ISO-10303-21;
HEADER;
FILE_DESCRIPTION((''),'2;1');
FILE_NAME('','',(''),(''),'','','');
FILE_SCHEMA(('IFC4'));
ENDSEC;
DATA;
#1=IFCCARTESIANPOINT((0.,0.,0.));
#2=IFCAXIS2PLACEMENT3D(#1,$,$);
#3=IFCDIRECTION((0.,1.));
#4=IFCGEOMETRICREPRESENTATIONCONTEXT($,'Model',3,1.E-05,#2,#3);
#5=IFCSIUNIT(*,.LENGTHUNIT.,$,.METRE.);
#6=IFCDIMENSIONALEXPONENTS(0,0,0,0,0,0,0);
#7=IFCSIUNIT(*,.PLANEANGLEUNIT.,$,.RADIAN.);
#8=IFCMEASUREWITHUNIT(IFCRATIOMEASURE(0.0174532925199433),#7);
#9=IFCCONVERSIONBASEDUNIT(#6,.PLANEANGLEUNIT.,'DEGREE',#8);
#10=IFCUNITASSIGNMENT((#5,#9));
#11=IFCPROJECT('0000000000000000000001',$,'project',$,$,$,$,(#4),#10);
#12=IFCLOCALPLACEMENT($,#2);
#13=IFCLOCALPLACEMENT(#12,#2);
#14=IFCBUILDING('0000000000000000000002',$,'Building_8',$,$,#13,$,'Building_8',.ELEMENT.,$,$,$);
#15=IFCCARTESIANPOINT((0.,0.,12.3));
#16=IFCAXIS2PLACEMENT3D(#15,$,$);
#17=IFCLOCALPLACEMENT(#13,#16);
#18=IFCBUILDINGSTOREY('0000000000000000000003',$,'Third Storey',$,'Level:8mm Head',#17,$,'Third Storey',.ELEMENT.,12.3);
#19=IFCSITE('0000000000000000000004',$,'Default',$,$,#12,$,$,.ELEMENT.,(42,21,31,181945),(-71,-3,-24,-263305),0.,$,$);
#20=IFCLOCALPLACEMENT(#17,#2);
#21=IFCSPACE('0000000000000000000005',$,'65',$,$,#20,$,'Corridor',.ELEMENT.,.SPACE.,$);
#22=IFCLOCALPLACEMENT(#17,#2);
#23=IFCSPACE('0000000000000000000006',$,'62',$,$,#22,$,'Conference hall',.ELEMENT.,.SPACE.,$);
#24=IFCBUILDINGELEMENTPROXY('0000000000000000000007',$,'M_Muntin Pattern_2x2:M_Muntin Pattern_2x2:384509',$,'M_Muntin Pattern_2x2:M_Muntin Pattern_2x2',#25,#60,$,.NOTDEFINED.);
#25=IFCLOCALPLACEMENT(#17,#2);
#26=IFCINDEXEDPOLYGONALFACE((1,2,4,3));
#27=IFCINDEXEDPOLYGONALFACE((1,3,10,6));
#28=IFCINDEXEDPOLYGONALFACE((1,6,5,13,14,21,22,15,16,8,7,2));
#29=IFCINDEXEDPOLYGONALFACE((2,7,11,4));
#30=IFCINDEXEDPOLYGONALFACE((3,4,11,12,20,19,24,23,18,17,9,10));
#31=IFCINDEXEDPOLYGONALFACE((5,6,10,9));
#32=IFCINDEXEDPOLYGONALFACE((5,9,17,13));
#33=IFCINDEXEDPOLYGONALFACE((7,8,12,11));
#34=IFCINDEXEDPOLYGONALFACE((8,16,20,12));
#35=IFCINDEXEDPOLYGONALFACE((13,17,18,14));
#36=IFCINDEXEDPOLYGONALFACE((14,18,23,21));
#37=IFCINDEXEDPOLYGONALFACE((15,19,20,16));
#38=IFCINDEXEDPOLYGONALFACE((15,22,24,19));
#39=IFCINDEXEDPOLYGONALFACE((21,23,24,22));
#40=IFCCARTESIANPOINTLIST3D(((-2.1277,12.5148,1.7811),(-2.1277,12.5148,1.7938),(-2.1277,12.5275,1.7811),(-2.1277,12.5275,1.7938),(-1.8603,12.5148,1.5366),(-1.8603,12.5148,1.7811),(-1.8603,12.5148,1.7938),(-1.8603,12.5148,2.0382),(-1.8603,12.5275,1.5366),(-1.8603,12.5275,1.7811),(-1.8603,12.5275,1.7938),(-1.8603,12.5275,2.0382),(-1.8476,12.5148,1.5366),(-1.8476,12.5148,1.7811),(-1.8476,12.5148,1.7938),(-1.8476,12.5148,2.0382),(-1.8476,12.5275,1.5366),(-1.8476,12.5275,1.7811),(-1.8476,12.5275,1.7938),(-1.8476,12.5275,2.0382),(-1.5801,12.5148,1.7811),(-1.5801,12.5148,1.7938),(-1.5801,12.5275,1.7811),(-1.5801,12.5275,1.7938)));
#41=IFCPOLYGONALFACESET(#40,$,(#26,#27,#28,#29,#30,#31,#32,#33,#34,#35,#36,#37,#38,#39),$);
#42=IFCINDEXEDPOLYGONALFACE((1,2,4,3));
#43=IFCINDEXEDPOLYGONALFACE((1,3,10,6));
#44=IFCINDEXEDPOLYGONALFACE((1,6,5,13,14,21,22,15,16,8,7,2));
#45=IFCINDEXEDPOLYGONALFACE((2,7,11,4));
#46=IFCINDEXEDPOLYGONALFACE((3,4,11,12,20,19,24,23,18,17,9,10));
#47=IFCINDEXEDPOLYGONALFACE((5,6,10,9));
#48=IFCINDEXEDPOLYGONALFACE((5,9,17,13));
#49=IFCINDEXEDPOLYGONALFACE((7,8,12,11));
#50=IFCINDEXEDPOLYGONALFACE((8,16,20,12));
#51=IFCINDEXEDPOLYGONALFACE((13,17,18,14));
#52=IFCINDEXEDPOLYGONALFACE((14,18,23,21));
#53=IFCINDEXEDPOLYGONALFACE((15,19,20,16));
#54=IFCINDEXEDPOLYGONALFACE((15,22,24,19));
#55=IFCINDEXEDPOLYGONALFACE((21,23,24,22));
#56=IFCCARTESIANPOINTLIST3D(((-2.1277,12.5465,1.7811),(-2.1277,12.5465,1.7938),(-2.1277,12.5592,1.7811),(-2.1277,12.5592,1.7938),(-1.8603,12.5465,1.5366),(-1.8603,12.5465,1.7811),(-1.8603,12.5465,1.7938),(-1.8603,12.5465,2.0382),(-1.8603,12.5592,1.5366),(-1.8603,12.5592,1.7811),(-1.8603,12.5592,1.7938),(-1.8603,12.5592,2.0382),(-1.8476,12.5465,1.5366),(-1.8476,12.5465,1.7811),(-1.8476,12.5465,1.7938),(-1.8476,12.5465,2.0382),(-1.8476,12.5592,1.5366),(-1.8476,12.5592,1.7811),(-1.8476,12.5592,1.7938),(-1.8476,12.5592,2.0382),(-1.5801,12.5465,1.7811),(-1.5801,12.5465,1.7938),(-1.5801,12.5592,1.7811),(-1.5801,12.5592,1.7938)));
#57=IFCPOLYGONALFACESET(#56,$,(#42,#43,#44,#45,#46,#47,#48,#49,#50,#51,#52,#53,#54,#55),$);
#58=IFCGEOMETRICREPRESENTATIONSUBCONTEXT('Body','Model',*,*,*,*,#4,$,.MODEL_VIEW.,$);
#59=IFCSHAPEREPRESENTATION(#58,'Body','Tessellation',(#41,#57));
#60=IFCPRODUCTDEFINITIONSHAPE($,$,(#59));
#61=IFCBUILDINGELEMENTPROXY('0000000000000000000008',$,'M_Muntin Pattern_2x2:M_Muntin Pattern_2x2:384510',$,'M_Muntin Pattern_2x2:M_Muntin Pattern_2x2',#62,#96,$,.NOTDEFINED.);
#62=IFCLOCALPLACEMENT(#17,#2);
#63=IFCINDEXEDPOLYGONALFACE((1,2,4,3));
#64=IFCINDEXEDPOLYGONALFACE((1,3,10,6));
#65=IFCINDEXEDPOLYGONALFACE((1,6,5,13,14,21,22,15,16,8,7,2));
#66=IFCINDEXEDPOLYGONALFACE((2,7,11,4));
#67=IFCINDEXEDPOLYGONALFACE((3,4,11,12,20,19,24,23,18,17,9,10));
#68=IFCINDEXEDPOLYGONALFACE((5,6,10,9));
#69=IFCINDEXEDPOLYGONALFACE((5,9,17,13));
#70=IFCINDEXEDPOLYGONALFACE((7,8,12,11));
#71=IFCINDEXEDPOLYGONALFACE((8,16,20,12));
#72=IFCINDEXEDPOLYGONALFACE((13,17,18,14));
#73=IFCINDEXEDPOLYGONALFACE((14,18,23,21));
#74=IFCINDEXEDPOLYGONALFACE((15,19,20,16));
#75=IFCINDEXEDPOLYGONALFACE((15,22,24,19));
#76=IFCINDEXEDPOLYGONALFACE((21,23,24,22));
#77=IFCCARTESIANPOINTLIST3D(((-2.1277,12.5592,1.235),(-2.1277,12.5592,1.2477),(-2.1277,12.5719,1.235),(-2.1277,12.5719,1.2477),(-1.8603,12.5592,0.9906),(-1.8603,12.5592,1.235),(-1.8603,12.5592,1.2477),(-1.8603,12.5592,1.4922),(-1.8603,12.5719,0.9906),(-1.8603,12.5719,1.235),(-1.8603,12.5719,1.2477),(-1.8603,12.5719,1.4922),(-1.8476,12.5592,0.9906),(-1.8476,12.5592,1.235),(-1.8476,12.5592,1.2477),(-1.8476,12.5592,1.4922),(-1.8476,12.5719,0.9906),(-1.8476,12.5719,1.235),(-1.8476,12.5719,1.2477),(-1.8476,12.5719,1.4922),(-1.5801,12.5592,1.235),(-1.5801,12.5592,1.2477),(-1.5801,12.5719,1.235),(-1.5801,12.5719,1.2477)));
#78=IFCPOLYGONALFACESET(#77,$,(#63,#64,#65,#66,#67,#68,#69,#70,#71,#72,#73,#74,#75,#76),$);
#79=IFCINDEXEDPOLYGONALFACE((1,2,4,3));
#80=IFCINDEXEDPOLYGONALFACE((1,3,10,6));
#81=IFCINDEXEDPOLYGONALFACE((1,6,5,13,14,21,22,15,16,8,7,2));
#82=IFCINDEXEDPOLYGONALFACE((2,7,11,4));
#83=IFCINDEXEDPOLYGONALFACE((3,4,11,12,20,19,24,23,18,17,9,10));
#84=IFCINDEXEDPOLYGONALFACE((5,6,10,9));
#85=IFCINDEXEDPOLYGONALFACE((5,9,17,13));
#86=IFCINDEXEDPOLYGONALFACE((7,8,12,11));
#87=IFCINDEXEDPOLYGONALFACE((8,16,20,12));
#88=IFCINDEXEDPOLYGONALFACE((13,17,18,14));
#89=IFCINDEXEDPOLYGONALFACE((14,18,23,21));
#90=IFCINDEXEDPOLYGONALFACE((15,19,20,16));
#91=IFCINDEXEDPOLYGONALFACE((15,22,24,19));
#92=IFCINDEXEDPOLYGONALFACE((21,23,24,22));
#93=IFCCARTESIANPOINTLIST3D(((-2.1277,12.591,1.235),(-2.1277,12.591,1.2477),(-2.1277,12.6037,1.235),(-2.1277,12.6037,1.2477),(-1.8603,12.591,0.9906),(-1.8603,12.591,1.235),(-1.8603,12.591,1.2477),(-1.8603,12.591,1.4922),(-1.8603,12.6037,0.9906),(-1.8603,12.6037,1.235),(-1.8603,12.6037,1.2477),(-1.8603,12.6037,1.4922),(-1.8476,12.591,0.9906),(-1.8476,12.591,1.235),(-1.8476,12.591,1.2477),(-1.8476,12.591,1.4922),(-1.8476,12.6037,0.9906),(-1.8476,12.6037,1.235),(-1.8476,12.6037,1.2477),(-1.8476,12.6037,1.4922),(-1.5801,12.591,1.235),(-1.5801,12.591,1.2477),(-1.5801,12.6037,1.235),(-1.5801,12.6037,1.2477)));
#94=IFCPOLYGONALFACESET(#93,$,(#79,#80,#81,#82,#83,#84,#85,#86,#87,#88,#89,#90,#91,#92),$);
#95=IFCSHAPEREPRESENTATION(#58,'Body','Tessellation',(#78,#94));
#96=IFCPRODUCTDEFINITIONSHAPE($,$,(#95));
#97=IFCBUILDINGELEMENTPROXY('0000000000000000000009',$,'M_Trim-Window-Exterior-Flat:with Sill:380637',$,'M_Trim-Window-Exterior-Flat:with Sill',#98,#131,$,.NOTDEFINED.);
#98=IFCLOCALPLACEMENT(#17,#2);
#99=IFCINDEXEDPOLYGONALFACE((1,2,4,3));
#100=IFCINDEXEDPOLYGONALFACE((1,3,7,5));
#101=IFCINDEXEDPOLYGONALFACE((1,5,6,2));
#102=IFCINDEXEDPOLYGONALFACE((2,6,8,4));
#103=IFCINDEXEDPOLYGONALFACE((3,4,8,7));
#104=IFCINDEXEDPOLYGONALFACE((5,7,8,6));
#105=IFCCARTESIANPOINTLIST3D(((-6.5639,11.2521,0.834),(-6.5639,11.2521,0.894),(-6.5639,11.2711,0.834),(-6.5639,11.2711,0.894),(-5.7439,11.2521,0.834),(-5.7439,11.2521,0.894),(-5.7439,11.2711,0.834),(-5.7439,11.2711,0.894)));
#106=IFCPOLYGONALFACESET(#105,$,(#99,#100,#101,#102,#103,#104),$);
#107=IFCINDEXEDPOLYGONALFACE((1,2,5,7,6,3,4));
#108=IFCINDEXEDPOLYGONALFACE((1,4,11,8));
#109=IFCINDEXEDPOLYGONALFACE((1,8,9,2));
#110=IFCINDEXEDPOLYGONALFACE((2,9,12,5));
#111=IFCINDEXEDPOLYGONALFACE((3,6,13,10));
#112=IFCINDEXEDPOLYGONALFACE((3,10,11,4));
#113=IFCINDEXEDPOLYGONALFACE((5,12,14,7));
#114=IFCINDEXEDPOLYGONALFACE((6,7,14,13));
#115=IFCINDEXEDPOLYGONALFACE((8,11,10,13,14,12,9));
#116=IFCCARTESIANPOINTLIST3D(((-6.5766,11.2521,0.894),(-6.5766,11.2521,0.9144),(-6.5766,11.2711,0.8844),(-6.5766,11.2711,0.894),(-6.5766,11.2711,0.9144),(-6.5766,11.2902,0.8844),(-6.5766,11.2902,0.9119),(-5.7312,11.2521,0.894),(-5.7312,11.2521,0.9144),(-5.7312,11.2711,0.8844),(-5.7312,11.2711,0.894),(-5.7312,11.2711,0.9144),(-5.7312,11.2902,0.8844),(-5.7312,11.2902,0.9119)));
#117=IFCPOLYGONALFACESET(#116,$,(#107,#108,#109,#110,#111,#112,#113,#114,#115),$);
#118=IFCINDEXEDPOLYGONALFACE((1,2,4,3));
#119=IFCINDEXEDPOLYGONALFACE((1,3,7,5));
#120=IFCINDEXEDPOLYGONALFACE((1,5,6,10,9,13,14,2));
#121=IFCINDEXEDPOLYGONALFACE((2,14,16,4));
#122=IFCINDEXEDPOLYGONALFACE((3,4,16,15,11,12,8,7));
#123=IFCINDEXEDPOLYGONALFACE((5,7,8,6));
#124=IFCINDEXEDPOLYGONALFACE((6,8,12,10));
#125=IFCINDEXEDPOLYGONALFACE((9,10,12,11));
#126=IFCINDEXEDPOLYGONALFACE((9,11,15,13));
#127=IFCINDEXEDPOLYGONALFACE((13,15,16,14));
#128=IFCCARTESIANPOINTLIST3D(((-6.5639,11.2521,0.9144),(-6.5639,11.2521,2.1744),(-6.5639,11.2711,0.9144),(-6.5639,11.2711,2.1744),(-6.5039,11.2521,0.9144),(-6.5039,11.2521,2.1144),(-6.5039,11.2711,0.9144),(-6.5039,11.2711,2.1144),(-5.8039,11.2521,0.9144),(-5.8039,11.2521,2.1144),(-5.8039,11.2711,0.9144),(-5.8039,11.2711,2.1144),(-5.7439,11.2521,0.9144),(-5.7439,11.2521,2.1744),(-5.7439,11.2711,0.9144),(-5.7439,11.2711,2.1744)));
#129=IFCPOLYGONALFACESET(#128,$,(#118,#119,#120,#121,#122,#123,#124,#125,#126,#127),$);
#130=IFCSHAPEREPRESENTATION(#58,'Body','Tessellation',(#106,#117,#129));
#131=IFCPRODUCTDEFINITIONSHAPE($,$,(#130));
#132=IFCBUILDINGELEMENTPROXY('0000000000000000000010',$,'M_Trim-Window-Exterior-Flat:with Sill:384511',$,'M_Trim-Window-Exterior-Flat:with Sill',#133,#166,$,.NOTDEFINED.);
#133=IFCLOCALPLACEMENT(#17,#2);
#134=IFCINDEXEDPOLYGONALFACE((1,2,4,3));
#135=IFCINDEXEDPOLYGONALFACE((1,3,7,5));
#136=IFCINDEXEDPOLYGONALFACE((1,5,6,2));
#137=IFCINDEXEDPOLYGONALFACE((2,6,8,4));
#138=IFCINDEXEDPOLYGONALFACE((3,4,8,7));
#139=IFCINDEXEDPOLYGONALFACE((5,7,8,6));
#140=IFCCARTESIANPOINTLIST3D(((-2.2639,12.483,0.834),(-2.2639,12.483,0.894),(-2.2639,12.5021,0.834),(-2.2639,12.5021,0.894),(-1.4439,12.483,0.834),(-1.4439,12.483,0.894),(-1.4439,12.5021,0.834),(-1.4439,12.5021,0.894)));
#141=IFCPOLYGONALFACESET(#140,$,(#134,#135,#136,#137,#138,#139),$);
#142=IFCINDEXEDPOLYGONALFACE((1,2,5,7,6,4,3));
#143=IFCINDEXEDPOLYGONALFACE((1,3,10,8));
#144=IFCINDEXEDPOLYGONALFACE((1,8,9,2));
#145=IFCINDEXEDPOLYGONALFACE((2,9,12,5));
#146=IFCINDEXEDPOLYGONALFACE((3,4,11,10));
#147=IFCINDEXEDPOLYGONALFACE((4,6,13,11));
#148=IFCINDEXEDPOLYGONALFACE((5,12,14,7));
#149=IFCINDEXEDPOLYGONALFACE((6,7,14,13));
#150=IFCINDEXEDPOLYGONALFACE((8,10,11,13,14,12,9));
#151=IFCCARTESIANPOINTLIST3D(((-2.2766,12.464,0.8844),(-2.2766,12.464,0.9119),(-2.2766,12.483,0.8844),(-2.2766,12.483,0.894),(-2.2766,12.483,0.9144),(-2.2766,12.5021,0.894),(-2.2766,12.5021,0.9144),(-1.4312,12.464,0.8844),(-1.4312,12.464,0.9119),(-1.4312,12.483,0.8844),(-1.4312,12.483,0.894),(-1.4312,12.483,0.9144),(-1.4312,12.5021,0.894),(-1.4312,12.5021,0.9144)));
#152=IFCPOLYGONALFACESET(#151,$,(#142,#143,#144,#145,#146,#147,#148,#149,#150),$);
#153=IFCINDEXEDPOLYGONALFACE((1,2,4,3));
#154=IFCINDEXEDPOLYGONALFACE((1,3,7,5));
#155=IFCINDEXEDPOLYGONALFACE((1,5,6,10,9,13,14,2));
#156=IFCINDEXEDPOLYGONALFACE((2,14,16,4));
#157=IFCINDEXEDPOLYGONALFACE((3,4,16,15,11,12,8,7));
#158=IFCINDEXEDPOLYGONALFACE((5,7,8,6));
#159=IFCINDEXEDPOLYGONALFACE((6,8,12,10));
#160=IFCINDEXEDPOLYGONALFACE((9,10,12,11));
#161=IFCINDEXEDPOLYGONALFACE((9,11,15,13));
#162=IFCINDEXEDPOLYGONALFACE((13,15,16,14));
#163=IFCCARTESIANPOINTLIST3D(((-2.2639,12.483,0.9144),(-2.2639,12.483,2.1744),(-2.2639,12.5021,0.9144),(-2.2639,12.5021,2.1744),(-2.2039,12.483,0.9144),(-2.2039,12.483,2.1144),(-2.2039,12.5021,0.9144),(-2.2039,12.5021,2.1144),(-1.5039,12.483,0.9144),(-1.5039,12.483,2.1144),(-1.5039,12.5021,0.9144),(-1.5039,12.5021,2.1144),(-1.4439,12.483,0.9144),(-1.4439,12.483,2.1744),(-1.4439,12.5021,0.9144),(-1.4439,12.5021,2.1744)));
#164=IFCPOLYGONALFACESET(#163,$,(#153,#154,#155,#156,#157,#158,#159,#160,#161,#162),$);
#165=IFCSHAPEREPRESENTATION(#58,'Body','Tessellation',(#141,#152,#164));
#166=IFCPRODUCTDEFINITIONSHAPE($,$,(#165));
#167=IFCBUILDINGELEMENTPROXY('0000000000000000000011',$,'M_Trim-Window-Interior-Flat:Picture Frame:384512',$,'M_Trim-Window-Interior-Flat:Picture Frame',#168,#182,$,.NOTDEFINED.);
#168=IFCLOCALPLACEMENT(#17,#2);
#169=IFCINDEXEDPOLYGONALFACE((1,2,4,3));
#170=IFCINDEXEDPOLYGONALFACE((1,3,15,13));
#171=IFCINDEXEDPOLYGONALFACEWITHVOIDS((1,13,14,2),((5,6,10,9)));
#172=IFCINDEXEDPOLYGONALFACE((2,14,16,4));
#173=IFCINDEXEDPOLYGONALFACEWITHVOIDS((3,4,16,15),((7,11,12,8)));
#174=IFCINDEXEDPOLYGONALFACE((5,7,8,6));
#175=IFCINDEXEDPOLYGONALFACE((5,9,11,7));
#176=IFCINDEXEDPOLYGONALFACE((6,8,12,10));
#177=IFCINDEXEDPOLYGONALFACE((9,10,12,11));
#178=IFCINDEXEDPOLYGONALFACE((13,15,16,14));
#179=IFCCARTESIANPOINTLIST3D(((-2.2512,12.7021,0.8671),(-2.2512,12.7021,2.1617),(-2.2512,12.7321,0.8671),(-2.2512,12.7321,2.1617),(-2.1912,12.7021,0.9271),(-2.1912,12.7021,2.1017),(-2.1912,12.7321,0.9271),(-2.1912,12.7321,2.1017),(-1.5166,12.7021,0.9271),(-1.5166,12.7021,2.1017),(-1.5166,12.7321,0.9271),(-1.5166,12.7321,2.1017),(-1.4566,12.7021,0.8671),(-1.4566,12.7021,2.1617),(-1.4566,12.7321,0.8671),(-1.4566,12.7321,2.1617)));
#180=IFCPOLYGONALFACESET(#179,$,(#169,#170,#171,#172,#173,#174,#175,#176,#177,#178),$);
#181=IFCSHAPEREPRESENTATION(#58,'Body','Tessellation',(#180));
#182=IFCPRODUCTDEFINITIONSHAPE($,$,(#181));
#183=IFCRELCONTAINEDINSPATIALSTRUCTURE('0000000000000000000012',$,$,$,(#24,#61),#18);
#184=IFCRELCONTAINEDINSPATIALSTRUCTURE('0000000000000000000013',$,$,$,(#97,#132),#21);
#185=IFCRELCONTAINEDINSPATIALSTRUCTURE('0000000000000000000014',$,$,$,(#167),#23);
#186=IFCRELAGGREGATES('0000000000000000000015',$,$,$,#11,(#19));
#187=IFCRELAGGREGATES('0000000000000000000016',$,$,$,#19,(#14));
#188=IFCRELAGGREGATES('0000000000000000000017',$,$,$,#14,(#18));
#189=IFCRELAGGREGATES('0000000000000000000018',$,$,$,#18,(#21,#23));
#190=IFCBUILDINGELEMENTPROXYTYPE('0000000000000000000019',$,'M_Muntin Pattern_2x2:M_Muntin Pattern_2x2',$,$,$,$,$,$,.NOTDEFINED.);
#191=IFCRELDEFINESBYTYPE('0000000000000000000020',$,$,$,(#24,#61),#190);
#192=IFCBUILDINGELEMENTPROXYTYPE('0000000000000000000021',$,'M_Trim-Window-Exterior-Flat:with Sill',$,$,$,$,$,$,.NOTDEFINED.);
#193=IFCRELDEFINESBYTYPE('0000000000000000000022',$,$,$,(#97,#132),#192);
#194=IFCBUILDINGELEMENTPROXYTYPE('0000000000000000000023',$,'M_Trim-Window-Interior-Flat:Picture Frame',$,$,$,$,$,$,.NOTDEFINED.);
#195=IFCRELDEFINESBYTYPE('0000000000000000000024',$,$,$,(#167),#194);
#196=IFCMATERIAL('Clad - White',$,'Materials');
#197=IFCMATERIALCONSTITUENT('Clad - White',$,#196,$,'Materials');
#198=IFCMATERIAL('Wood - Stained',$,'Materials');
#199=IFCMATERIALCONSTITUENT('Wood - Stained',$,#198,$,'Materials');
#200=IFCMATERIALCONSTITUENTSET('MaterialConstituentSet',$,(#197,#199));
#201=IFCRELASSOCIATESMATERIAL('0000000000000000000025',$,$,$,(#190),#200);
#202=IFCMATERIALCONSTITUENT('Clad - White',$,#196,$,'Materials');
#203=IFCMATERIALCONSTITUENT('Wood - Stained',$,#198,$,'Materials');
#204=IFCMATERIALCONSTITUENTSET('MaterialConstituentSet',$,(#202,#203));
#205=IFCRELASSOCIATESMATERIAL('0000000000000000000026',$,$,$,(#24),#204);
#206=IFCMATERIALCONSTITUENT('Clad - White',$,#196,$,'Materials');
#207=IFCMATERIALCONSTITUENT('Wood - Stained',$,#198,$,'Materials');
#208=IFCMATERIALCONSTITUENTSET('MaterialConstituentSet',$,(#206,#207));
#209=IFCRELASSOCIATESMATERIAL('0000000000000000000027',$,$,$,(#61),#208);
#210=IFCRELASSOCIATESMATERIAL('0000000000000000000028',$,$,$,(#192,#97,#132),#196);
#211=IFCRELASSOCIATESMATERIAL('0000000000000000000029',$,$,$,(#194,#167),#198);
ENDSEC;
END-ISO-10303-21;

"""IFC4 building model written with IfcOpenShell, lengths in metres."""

from ifc_helpers import new_model, entity, si_unit, converted_unit, direction, frame, origin, place, context, subcontext, project, spatial, indexed_curve, outline, extrude, source, transform, mapped, material, constituent, constituent_set, type_object, type_shapes, element, save


model = new_model("IFC4")

# Units and contexts
model_context = context("Model", 3, precision=1e-05, world=origin(), true_north=direction((0.0, 1.0)))
body_context = subcontext(model_context, "Body", "Model", "MODEL_VIEW")
ifc_project = project(units=[si_unit("LENGTHUNIT", "METRE"), converted_unit("PLANEANGLEUNIT", "DEGREE", entity("IfcRatioMeasure", 0.0174532925199433), si_unit("PLANEANGLEUNIT", "RADIAN"), dimensions=[0, 0, 0, 0, 0, 0, 0])], contexts=[model_context])

# Site, building, storey
site_placement = place(None, origin())
site = spatial("IfcSite", under=ifc_project, at=site_placement, Name="Default", CompositionType="ELEMENT", RefLatitude=(42, 21, 31, 181945), RefLongitude=(-71, -3, -24, -263305), RefElevation=0.0)
building_placement = place(site_placement, origin())
building = spatial("IfcBuilding", under=site, at=building_placement, Name="Building_8", LongName="Building_8", CompositionType="ELEMENT")
storey_placement = place(building_placement, frame((0.0, 0.0, 12.3)))
storey = spatial("IfcBuildingStorey", under=building, at=storey_placement, Name="Third Storey", ObjectType="Level:8mm Head", LongName="Third Storey", CompositionType="ELEMENT", Elevation=12.3)

# Building element proxies
ifc_material_1 = material(Name="Clad - White", Category="Materials")
ifc_constituent_1 = constituent(ifc_material_1, Name="Clad - White", Category="Materials")
ifc_material_2 = material(Name="Wood - Stained", Category="Materials")
ifc_constituent_2 = constituent(ifc_material_2, Name="Wood - Stained", Category="Materials")
ifc_constituent_set_1 = constituent_set(constituents=[ifc_constituent_1, ifc_constituent_2], Name="MaterialConstituentSet")
ifc_constituent_3 = constituent(ifc_material_1, Name="Clad - White", Category="Materials")
ifc_constituent_4 = constituent(ifc_material_2, Name="Wood - Stained", Category="Materials")
ifc_constituent_set_2 = constituent_set(constituents=[ifc_constituent_3, ifc_constituent_4], Name="MaterialConstituentSet")
building_element_proxy_type_1 = type_object("IfcBuildingElementProxyType", Name="M_Muntin Pattern_2x2:M_Muntin Pattern_2x2", PredefinedType="NOTDEFINED", material=ifc_constituent_set_2)
shared_shape_1 = source(origin(), body_context, "Body", "SweptSolid", [
    extrude(outline(indexed_curve([(0.0064, -0.0064), (0.2508, -0.0064), (0.2508, 0.0063), (0.0064, 0.0063), (0.0064, 0.2738), (-0.0063, 0.2738), (-0.0063, 0.0063), (-0.2508, 0.0063), (-0.2508, -0.0064), (-0.0063, -0.0064), (-0.0063, -0.2738), (0.0064, -0.2738), (0.0064, -0.0064)], self_intersect=False)), frame((0.0, -0.0222, 0.2508), z_axis=(0.0, 1.0, 0.0), x_axis=(0.0, 0.0, 1.0)), (0.0, 0.0, 1.0), 0.0127),
    extrude(outline(indexed_curve([(0.0064, -0.0064), (0.2508, -0.0064), (0.2508, 0.0063), (0.0064, 0.0063), (0.0064, 0.2738), (-0.0063, 0.2738), (-0.0063, 0.0063), (-0.2508, 0.0063), (-0.2508, -0.0064), (-0.0063, -0.0064), (-0.0063, -0.2738), (0.0064, -0.2738), (0.0064, -0.0064)], self_intersect=False)), frame((0.0, 0.0095, 0.2508), z_axis=(0.0, 1.0, 0.0), x_axis=(0.0, 0.0, 1.0)), (0.0, 0.0, 1.0), 0.0127),
])
type_shapes(building_element_proxy_type_1, [shared_shape_1])
proxy_1_placement = place(storey_placement, frame((-1.8539, 12.537, 1.5366)))
element("IfcBuildingElementProxy", 1, at=proxy_1_placement, inside=storey, type_object=building_element_proxy_type_1, material=ifc_constituent_set_1, Name="M_Muntin Pattern_2x2:M_Muntin Pattern_2x2:384509", ObjectType="M_Muntin Pattern_2x2:M_Muntin Pattern_2x2", PredefinedType="NOTDEFINED", context=body_context, shape_type="MappedRepresentation", body=[
    mapped(shared_shape_1, transform((0.0, 0.0, 0.0), scale=1.0)),
])
ifc_constituent_5 = constituent(ifc_material_1, Name="Clad - White", Category="Materials")
ifc_constituent_6 = constituent(ifc_material_2, Name="Wood - Stained", Category="Materials")
ifc_constituent_set_3 = constituent_set(constituents=[ifc_constituent_5, ifc_constituent_6], Name="MaterialConstituentSet")
proxy_2_placement = place(storey_placement, frame((-1.8539, 12.5814, 0.9906)))
element("IfcBuildingElementProxy", 2, at=proxy_2_placement, inside=storey, type_object=building_element_proxy_type_1, material=ifc_constituent_set_3, Name="M_Muntin Pattern_2x2:M_Muntin Pattern_2x2:384510", ObjectType="M_Muntin Pattern_2x2:M_Muntin Pattern_2x2", PredefinedType="NOTDEFINED", context=body_context, shape_type="MappedRepresentation", body=[
    mapped(shared_shape_1, transform((0.0, 0.0, 0.0), scale=1.0)),
])

# Shared definitions
space_1_placement = place(storey_placement, origin())
space_1 = spatial("IfcSpace", under=storey, at=space_1_placement, Name="65", LongName="Corridor", CompositionType="ELEMENT", PredefinedType="SPACE")

# Building element proxies
building_element_proxy_type_2 = type_object("IfcBuildingElementProxyType", Name="M_Trim-Window-Exterior-Flat:with Sill", PredefinedType="NOTDEFINED", material=ifc_material_1)
shared_shape_2 = source(origin(), body_context, "Body", "SweptSolid", [
    extrude(outline(indexed_curve([(-0.03, -0.41), (0.03, -0.41), (0.03, 0.41), (-0.03, 0.41), (-0.03, -0.41)], self_intersect=False)), frame((0.0, 1.2504, 0.0), z_axis=(0.0, 0.0, 1.0), x_axis=(0.0, 1.0, 0.0)), (0.0, 0.0, 1.0), 0.0191),
    extrude(outline(indexed_curve([(-0.0152, -0.019), (0.0123, -0.019), (0.0148, 0.0), (0.0148, 0.019), (-0.0057, 0.019), (-0.0057, 0.0), (-0.0152, 0.0), (-0.0152, -0.019)], self_intersect=False)), frame((-0.4227, 1.2148, 0.019), z_axis=(1.0, 0.0, 0.0), x_axis=(0.0, -1.0, 0.0)), (0.0, 0.0, 1.0), 0.8454),
    extrude(outline(indexed_curve([(-0.41, -0.645), (0.41, -0.645), (0.41, 0.615), (0.35, 0.615), (0.35, -0.585), (-0.35, -0.585), (-0.35, 0.615), (-0.41, 0.615), (-0.41, -0.645)], self_intersect=False)), frame((0.0, 0.585, 0.0)), (0.0, 0.0, 1.0), 0.0191),
])
type_shapes(building_element_proxy_type_2, [shared_shape_2])
for number, where, z_axis, x_axis, name in (
    (3, (-6.1539, 11.2521, 2.1144), (0.0, 1.0, 0.0), (1.0, 0.0, 0.0), "M_Trim-Window-Exterior-Flat:with Sill:380637"),
    (4, (-1.8539, 12.5021, 2.1144), (0.0, -1.0, 0.0), (-1.0, 0.0, 0.0), "M_Trim-Window-Exterior-Flat:with Sill:384511"),
):
    element("IfcBuildingElementProxy", number, at=place(space_1_placement, frame(where, z_axis=z_axis, x_axis=x_axis)), inside=space_1, type_object=building_element_proxy_type_2, material=ifc_material_1, Name=name, ObjectType="M_Trim-Window-Exterior-Flat:with Sill", PredefinedType="NOTDEFINED", context=body_context, shape_type="MappedRepresentation", body=[
        mapped(shared_shape_2, transform((0.0, 0.0, 0.0), scale=1.0)),
    ])

# Shared definitions
space_2_placement = place(storey_placement, origin())
space_2 = spatial("IfcSpace", under=storey, at=space_2_placement, Name="62", LongName="Conference hall", CompositionType="ELEMENT", PredefinedType="SPACE")

# Building element proxy
building_element_proxy_type_3 = type_object("IfcBuildingElementProxyType", Name="M_Trim-Window-Interior-Flat:Picture Frame", PredefinedType="NOTDEFINED", material=ifc_material_2)
shared_shape_3 = source(origin(), body_context, "Body", "SweptSolid", [
    extrude(outline(indexed_curve([(-0.6473, -0.3973), (0.6473, -0.3973), (0.6473, 0.3973), (-0.6473, 0.3973), (-0.6473, -0.3973)], self_intersect=False), holes=[indexed_curve([(-0.5873, -0.3373), (-0.5873, 0.3373), (0.5873, 0.3373), (0.5873, -0.3373), (-0.5873, -0.3373)], self_intersect=False)]), frame((0.0, 0.6, 0.0), z_axis=(0.0, 0.0, 1.0), x_axis=(0.0, 1.0, 0.0)), (0.0, 0.0, 1.0), 0.03),
])
type_shapes(building_element_proxy_type_3, [shared_shape_3])
proxy_3_placement = place(space_2_placement, frame((-1.8539, 12.7021, 2.1144), z_axis=(0.0, 1.0, 0.0), x_axis=(1.0, 0.0, 0.0)))
element("IfcBuildingElementProxy", 5, at=proxy_3_placement, inside=space_2, type_object=building_element_proxy_type_3, material=ifc_material_2, Name="M_Trim-Window-Interior-Flat:Picture Frame:384512", ObjectType="M_Trim-Window-Interior-Flat:Picture Frame", PredefinedType="NOTDEFINED", context=body_context, shape_type="MappedRepresentation", body=[
    mapped(shared_shape_3, transform((0.0, 0.0, 0.0), scale=1.0)),
])

save(model, "model.ifc")
